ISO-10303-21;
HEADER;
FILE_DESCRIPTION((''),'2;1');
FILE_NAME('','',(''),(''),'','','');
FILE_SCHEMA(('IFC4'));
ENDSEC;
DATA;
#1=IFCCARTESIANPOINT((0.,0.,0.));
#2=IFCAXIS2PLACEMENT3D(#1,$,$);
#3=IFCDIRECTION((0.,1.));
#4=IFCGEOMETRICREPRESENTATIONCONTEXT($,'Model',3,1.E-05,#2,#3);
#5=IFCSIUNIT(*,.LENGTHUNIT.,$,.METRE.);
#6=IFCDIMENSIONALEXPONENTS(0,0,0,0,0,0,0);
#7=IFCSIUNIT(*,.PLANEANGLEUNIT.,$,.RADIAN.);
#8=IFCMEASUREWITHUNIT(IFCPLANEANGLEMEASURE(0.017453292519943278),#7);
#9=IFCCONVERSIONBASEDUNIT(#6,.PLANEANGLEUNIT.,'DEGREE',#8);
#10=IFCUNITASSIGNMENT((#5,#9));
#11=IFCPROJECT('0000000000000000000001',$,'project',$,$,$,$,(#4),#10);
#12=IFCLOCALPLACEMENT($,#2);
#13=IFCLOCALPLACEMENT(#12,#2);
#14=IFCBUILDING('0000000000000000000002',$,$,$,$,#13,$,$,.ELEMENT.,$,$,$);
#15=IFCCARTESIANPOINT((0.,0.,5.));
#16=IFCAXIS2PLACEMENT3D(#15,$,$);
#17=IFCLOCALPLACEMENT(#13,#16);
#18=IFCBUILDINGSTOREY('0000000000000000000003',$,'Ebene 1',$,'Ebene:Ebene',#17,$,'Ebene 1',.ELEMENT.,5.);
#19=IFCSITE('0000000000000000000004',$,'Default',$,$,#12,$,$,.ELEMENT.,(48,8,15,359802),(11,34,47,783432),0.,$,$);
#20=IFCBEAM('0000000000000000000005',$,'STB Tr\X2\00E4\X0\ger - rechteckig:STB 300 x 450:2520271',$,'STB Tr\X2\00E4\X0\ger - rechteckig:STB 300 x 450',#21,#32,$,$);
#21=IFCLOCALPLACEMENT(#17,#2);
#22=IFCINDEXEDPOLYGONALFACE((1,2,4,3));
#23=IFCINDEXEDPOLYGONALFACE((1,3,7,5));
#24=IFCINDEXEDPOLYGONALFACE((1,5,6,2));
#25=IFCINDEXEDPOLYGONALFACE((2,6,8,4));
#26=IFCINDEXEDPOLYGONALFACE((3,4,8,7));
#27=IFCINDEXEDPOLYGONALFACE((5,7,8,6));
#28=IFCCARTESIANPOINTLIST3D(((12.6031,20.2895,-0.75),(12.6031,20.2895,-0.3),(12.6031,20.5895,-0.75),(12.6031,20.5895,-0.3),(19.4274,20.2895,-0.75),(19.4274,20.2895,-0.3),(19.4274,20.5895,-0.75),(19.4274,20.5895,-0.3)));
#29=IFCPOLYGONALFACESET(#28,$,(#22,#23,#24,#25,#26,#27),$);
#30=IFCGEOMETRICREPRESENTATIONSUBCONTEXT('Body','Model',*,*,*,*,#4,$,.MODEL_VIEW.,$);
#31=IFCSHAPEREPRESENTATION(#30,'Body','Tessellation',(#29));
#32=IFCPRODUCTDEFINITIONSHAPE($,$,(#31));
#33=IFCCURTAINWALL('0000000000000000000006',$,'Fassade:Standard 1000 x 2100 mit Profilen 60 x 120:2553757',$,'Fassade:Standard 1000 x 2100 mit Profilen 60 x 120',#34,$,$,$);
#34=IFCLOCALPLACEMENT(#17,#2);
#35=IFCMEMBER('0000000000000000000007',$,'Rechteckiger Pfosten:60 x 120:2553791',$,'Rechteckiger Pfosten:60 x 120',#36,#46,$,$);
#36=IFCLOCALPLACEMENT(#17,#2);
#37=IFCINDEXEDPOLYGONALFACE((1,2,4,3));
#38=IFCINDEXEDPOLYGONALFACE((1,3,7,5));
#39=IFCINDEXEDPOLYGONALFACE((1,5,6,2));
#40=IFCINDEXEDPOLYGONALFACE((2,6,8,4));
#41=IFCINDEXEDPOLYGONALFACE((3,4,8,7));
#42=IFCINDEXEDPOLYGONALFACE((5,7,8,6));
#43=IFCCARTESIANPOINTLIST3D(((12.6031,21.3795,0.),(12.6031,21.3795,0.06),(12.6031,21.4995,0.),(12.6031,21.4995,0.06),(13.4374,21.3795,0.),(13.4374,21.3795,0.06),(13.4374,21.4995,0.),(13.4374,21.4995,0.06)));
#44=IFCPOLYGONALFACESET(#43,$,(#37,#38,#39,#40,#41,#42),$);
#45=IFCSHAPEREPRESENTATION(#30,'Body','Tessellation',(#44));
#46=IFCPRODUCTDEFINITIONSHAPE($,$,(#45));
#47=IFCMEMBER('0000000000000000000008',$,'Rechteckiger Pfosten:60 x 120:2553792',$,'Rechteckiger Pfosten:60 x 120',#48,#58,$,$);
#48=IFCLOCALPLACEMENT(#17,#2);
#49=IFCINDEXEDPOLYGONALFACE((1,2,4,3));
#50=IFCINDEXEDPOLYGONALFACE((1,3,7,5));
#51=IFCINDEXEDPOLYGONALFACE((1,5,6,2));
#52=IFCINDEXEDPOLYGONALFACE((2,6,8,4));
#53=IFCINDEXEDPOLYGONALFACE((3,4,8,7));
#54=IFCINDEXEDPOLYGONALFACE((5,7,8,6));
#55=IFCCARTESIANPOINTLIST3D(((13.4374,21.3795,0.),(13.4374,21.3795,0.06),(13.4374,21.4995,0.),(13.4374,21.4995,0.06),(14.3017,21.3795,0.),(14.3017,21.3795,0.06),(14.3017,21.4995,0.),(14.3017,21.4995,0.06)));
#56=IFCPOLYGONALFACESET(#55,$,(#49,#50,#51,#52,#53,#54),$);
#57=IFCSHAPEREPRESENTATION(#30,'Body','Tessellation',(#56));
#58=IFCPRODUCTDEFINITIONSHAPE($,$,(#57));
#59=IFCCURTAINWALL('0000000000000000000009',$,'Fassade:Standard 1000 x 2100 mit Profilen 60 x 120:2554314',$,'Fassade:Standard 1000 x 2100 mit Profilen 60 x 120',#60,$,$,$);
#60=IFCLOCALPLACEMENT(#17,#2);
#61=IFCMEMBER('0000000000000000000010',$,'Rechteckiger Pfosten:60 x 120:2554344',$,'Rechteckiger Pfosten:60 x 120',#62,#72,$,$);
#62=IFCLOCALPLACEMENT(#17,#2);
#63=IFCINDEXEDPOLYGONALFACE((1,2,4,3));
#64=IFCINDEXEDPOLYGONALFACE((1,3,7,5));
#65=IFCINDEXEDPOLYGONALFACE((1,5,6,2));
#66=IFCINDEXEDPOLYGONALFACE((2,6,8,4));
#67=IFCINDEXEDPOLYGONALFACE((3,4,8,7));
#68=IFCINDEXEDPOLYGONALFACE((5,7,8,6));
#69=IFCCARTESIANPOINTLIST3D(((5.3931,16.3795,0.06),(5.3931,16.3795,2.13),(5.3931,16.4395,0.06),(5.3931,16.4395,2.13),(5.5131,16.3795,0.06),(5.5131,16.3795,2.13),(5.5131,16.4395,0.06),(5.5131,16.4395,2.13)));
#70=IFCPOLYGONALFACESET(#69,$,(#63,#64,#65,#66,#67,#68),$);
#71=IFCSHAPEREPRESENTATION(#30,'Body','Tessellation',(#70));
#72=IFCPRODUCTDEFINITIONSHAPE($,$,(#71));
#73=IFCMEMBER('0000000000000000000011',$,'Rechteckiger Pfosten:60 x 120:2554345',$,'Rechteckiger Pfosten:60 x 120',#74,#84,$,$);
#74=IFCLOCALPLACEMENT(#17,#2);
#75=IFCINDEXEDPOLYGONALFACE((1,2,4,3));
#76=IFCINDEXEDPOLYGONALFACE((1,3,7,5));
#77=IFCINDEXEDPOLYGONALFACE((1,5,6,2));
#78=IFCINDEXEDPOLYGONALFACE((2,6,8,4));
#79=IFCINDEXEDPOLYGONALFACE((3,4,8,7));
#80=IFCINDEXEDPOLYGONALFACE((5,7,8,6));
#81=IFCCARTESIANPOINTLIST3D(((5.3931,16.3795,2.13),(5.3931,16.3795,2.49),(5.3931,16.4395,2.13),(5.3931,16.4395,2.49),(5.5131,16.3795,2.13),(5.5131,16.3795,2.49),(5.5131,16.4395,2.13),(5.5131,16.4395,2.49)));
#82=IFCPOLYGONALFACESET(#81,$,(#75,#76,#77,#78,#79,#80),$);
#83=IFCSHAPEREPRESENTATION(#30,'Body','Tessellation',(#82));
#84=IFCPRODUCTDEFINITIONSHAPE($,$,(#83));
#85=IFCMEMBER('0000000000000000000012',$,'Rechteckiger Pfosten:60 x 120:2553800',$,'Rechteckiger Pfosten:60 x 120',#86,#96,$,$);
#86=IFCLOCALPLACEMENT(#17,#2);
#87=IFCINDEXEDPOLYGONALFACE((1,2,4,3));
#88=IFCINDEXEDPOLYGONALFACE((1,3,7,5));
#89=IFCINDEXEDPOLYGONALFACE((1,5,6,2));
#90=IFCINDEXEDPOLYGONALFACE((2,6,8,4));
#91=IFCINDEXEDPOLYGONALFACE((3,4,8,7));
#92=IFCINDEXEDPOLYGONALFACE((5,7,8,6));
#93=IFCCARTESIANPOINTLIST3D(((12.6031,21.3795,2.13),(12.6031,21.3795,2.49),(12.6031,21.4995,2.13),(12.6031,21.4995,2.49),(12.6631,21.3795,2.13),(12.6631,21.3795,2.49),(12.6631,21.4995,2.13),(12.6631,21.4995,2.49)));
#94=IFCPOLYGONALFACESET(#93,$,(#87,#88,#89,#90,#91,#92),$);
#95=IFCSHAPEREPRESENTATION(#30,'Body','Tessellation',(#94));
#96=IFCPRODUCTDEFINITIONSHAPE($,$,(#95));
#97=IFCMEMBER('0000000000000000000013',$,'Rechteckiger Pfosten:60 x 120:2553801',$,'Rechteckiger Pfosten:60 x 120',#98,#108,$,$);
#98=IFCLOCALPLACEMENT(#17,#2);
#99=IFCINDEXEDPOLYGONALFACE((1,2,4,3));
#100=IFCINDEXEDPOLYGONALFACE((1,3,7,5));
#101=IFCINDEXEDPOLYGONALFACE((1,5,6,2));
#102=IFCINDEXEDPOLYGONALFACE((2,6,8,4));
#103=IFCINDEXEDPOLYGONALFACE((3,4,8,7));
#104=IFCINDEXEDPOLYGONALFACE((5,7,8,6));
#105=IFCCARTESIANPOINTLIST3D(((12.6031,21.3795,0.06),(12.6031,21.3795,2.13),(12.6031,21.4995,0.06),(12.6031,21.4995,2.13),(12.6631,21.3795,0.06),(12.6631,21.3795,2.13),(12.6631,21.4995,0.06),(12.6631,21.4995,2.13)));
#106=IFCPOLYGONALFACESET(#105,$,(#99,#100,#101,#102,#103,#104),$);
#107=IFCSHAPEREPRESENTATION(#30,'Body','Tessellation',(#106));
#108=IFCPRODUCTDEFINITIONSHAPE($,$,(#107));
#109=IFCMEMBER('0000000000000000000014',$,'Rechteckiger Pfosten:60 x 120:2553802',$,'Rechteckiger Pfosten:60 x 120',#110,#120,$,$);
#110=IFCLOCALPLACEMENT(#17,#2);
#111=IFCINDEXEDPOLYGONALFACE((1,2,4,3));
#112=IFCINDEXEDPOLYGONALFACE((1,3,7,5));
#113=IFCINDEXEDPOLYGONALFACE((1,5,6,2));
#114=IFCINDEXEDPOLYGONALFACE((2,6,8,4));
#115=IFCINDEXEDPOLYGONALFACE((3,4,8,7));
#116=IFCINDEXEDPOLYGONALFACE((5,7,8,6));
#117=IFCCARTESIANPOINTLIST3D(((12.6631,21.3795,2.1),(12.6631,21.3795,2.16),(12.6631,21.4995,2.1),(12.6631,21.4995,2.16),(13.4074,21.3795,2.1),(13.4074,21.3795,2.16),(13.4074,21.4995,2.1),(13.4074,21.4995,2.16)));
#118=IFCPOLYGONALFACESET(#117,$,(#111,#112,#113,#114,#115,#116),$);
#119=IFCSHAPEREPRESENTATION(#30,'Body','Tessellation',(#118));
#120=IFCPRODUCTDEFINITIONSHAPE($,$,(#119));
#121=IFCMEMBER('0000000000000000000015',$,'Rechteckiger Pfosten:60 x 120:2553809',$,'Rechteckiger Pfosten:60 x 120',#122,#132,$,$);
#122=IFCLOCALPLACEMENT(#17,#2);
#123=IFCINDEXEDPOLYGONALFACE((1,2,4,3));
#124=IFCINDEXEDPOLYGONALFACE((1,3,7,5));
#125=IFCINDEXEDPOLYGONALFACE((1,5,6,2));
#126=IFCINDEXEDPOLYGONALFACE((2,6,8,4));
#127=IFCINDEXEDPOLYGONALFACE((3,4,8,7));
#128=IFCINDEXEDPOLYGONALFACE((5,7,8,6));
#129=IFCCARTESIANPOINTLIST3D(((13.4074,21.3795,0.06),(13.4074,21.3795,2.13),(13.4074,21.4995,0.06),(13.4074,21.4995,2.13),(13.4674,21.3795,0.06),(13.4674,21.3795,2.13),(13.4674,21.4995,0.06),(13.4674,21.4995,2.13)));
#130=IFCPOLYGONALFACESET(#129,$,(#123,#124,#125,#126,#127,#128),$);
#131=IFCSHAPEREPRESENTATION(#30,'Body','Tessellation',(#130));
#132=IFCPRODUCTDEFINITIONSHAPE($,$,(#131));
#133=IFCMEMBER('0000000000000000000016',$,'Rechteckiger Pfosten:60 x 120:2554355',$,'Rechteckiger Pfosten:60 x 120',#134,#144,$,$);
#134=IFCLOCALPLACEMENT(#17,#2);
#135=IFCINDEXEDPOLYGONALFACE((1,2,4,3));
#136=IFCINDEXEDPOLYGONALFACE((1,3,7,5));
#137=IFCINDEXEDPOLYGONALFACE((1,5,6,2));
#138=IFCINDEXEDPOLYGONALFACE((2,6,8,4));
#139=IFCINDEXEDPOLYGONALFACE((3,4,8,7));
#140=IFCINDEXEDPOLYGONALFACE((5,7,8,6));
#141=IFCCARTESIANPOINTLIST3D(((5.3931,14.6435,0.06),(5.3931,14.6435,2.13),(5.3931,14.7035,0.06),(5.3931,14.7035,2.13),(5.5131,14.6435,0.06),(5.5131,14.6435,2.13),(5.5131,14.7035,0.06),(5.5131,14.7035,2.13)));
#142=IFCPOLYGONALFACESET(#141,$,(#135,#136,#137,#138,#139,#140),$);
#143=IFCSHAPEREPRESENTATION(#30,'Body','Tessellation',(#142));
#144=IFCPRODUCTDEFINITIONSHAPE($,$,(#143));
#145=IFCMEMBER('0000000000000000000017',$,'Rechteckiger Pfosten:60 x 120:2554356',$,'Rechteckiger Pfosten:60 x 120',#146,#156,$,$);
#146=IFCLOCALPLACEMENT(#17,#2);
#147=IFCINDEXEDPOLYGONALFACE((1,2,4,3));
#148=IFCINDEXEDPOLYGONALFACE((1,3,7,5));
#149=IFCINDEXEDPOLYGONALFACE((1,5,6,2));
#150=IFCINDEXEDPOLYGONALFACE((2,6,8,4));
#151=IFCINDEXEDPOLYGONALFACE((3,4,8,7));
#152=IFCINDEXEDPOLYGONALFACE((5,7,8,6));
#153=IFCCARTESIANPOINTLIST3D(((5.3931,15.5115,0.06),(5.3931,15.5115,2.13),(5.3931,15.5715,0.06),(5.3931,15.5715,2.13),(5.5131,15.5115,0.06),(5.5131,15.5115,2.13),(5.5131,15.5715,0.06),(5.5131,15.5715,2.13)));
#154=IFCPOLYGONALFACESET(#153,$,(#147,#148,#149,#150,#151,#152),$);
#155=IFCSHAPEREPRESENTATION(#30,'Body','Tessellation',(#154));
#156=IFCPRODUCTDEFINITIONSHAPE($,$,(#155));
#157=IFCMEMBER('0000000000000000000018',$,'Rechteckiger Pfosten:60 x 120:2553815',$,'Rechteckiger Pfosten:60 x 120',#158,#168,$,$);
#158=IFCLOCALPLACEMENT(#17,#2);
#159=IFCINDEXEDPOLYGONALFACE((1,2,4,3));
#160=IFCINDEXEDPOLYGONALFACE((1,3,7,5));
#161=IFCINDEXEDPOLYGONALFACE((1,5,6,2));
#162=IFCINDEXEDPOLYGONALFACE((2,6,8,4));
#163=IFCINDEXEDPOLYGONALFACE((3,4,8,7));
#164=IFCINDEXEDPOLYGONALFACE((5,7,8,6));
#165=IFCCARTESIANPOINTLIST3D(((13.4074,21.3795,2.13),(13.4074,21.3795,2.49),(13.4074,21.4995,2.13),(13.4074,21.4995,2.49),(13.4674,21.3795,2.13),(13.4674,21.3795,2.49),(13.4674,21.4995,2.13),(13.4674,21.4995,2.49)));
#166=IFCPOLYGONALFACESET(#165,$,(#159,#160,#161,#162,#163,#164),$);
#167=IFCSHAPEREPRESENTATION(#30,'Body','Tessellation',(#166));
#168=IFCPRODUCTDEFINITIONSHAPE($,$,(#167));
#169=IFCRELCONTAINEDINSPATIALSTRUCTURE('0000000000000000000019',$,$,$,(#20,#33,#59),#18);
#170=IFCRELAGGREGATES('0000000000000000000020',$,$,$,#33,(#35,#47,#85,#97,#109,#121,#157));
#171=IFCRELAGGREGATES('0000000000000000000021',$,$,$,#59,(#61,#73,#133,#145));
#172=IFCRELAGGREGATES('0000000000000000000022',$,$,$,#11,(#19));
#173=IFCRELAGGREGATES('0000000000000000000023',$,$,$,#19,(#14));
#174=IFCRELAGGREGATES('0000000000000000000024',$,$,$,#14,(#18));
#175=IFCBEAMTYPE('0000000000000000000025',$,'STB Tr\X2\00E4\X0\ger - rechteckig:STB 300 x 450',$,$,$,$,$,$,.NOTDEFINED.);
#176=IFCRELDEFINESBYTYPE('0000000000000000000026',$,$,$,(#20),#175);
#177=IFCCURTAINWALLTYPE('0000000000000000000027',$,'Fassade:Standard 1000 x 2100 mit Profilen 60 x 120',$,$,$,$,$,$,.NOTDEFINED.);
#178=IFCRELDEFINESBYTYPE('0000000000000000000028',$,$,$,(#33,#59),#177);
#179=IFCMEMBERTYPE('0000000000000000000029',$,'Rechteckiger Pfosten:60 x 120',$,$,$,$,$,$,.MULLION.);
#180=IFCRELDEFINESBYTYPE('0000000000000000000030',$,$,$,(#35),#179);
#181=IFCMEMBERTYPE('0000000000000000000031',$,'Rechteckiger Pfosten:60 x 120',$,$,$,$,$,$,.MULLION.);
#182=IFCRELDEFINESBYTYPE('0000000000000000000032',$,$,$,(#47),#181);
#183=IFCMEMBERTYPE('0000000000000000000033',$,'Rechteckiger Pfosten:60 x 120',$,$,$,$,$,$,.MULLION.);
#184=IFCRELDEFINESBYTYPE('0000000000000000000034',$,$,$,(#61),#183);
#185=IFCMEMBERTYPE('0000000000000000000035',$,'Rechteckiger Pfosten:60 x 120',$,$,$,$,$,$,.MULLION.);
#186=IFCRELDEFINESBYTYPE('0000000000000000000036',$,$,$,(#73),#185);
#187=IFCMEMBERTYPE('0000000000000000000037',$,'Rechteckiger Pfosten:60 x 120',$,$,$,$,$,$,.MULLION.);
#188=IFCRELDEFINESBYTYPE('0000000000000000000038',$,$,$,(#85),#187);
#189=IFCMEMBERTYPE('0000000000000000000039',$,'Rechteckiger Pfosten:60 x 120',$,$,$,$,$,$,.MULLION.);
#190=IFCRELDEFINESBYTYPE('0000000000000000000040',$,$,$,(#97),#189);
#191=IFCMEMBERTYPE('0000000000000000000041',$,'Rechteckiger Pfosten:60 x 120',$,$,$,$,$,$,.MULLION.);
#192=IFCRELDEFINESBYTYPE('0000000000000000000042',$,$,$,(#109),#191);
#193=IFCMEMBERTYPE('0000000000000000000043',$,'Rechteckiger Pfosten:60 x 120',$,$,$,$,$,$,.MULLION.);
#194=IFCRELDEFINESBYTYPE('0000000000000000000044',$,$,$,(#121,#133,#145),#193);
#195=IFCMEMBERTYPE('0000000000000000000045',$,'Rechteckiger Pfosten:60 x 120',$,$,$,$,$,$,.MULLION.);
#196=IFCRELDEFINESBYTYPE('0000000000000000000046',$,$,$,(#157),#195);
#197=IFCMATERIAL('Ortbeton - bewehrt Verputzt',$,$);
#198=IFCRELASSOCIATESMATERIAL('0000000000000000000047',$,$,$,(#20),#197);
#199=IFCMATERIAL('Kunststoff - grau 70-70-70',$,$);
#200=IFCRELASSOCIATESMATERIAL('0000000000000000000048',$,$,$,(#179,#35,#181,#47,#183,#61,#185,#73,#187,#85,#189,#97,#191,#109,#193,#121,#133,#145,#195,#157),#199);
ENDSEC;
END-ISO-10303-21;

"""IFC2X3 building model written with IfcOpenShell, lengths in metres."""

from ifc_helpers import new_model, entity, si_unit, converted_unit, direction, frame, frame_2d, origin, origin_2d_with_axis, place, context, subcontext, project, spatial, rectangle, extrude, source, transform, mapped, material, type_object, type_shapes, element, aggregate, save


model = new_model("IFC2X3")

# Units and contexts
model_context = context("Model", 3, precision=1e-05, world=origin(), true_north=direction((0.0, 1.0)))
body_context = subcontext(model_context, "Body", "Model", "MODEL_VIEW")
ifc_project = project(units=[si_unit("LENGTHUNIT", "METRE"), converted_unit("PLANEANGLEUNIT", "DEGREE", entity("IfcPlaneAngleMeasure", 0.017453292519943278), si_unit("PLANEANGLEUNIT", "RADIAN"), dimensions=[0, 0, 0, 0, 0, 0, 0])], contexts=[model_context])

# Site, building, storey
site_placement = place(None, origin())
site = spatial("IfcSite", under=ifc_project, at=site_placement, Name="Default", CompositionType="ELEMENT", RefLatitude=(48, 8, 15, 359802), RefLongitude=(11, 34, 47, 783432), RefElevation=0.0)
building_placement = place(site_placement, origin())
building = spatial("IfcBuilding", under=site, at=building_placement, CompositionType="ELEMENT")
storey_placement = place(building_placement, frame((0.0, 0.0, 5.0)))
storey = spatial("IfcBuildingStorey", under=building, at=storey_placement, Name="Ebene 1", ObjectType="Ebene:Ebene", LongName="Ebene 1", CompositionType="ELEMENT", Elevation=5.0)

# Beam
ifc_material_1 = material(Name="Ortbeton - bewehrt Verputzt")
beam_type = type_object("IfcBeamType", Name="STB Träger - rechteckig:STB 300 x 450", PredefinedType="NOTDEFINED")
beam_1_placement = place(storey_placement, frame((12.4531, 20.4395, 0.0)))
element("IfcBeam", 1, at=beam_1_placement, inside=storey, type_object=beam_type, material=ifc_material_1, Name="STB Träger - rechteckig:STB 300 x 450:2520271", ObjectType="STB Träger - rechteckig:STB 300 x 450", context=body_context, shape_type="SweptSolid", body=[
    extrude(rectangle(XDim=0.45, YDim=0.3, at=frame_2d((0.0, 0.0), x_axis=(1.0, 0.0))), frame((0.15, 0.0, -0.525), z_axis=(1.0, 0.0, 0.0), x_axis=(0.0, 0.0, -1.0)), (0.0, 0.0, 1.0), 6.8243),
])

# Curtain walls, members
curtain_wall_type = type_object("IfcCurtainWallType", Name="Fassade:Standard 1000 x 2100 mit Profilen 60 x 120", PredefinedType="NOTDEFINED")
curtain_wall_1_placement = place(storey_placement, frame((0.0, 0.0, -5.0)))
curtain_wall_1 = element("IfcCurtainWall", 2, at=curtain_wall_1_placement, inside=storey, type_object=curtain_wall_type, Name="Fassade:Standard 1000 x 2100 mit Profilen 60 x 120:2553757", ObjectType="Fassade:Standard 1000 x 2100 mit Profilen 60 x 120")
ifc_material_2 = material(Name="Kunststoff - grau 70-70-70")
member_type_1 = type_object("IfcMemberType", Name="Rechteckiger Pfosten:60 x 120", PredefinedType="MULLION", material=ifc_material_2)
shared_shape_1 = source(origin(), body_context, "Body", "SweptSolid", [
    extrude(rectangle(XDim=0.06, YDim=0.12, at=origin_2d_with_axis()), frame((-0.03, 0.0, -0.8343), z_axis=(0.0, 0.0, 1.0), x_axis=(-1.0, 0.0, 0.0)), (0.0, 0.0, 1.0), 0.8343),
])
type_shapes(member_type_1, [shared_shape_1])
member_1_placement = place(curtain_wall_1_placement, frame((12.6031, 21.4395, 5.0), z_axis=(-1.0, 0.0, 0.0), x_axis=(0.0, 0.0, -1.0)))
member_1 = element("IfcMember", 3, at=member_1_placement, type_object=member_type_1, material=ifc_material_2, Name="Rechteckiger Pfosten:60 x 120:2553791", ObjectType="Rechteckiger Pfosten:60 x 120", context=body_context, shape_type="MappedRepresentation", body=[
    mapped(shared_shape_1, transform((0.0, 0.0, 0.0), scale=1.0)),
])
member_type_2 = type_object("IfcMemberType", Name="Rechteckiger Pfosten:60 x 120", PredefinedType="MULLION", material=ifc_material_2)
shared_shape_2 = source(origin(), body_context, "Body", "SweptSolid", [
    extrude(rectangle(XDim=0.06, YDim=0.12, at=origin_2d_with_axis()), frame((-0.03, 0.0, -0.8643), z_axis=(0.0, 0.0, 1.0), x_axis=(-1.0, 0.0, 0.0)), (0.0, 0.0, 1.0), 0.8643),
])
type_shapes(member_type_2, [shared_shape_2])
member_2_placement = place(curtain_wall_1_placement, frame((13.4374, 21.4395, 5.0), z_axis=(-1.0, 0.0, 0.0), x_axis=(0.0, 0.0, -1.0)))
member_2 = element("IfcMember", 4, at=member_2_placement, type_object=member_type_2, material=ifc_material_2, Name="Rechteckiger Pfosten:60 x 120:2553792", ObjectType="Rechteckiger Pfosten:60 x 120", context=body_context, shape_type="MappedRepresentation", body=[
    mapped(shared_shape_2, transform((0.0, 0.0, 0.0), scale=1.0)),
])
curtain_wall_2_placement = place(storey_placement, frame((0.0, 0.0, -5.0)))
curtain_wall_2 = element("IfcCurtainWall", 5, at=curtain_wall_2_placement, inside=storey, type_object=curtain_wall_type, Name="Fassade:Standard 1000 x 2100 mit Profilen 60 x 120:2554314", ObjectType="Fassade:Standard 1000 x 2100 mit Profilen 60 x 120")
member_type_3 = type_object("IfcMemberType", Name="Rechteckiger Pfosten:60 x 120", PredefinedType="MULLION", material=ifc_material_2)
shared_shape_3 = source(origin(), body_context, "Body", "SweptSolid", [
    extrude(rectangle(XDim=0.06, YDim=0.12, at=origin_2d_with_axis()), frame((-0.03, 0.0, -2.07), z_axis=(0.0, 0.0, 1.0), x_axis=(-1.0, 0.0, 0.0)), (0.0, 0.0, 1.0), 2.07),
])
type_shapes(member_type_3, [shared_shape_3])
member_3_placement = place(curtain_wall_2_placement, frame((5.4531, 16.4395, 5.06), z_axis=(0.0, 0.0, -1.0), x_axis=(0.0, 1.0, 0.0)))
member_3 = element("IfcMember", 6, at=member_3_placement, type_object=member_type_3, material=ifc_material_2, Name="Rechteckiger Pfosten:60 x 120:2554344", ObjectType="Rechteckiger Pfosten:60 x 120", context=body_context, shape_type="MappedRepresentation", body=[
    mapped(shared_shape_3, transform((0.0, 0.0, 0.0), scale=1.0)),
])
member_type_4 = type_object("IfcMemberType", Name="Rechteckiger Pfosten:60 x 120", PredefinedType="MULLION", material=ifc_material_2)
shared_shape_4 = source(origin(), body_context, "Body", "SweptSolid", [
    extrude(rectangle(XDim=0.06, YDim=0.12, at=origin_2d_with_axis()), frame((-0.03, 0.0, -0.36), z_axis=(0.0, 0.0, 1.0), x_axis=(-1.0, 0.0, 0.0)), (0.0, 0.0, 1.0), 0.36),
])
type_shapes(member_type_4, [shared_shape_4])
member_4_placement = place(curtain_wall_2_placement, frame((5.4531, 16.4395, 7.13), z_axis=(0.0, 0.0, -1.0), x_axis=(0.0, 1.0, 0.0)))
member_4 = element("IfcMember", 7, at=member_4_placement, type_object=member_type_4, material=ifc_material_2, Name="Rechteckiger Pfosten:60 x 120:2554345", ObjectType="Rechteckiger Pfosten:60 x 120", context=body_context, shape_type="MappedRepresentation", body=[
    mapped(shared_shape_4, transform((0.0, 0.0, 0.0), scale=1.0)),
])

# Members
member_type_5 = type_object("IfcMemberType", Name="Rechteckiger Pfosten:60 x 120", PredefinedType="MULLION", material=ifc_material_2)
shared_shape_5 = source(origin(), body_context, "Body", "SweptSolid", [
    extrude(rectangle(XDim=0.06, YDim=0.12, at=origin_2d_with_axis()), frame((-0.03, 0.0, -0.36), z_axis=(0.0, 0.0, 1.0), x_axis=(-1.0, 0.0, 0.0)), (0.0, 0.0, 1.0), 0.36),
])
type_shapes(member_type_5, [shared_shape_5])
member_5_placement = place(curtain_wall_1_placement, frame((12.6031, 21.4395, 7.49), z_axis=(0.0, 0.0, 1.0), x_axis=(-1.0, 0.0, 0.0)))
member_5 = element("IfcMember", 8, at=member_5_placement, type_object=member_type_5, material=ifc_material_2, Name="Rechteckiger Pfosten:60 x 120:2553800", ObjectType="Rechteckiger Pfosten:60 x 120", context=body_context, shape_type="MappedRepresentation", body=[
    mapped(shared_shape_5, transform((0.0, 0.0, 0.0), scale=1.0)),
])
member_type_6 = type_object("IfcMemberType", Name="Rechteckiger Pfosten:60 x 120", PredefinedType="MULLION", material=ifc_material_2)
shared_shape_6 = source(origin(), body_context, "Body", "SweptSolid", [
    extrude(rectangle(XDim=0.06, YDim=0.12, at=origin_2d_with_axis()), frame((-0.03, 0.0, -2.07), z_axis=(0.0, 0.0, 1.0), x_axis=(-1.0, 0.0, 0.0)), (0.0, 0.0, 1.0), 2.07),
])
type_shapes(member_type_6, [shared_shape_6])
member_6_placement = place(curtain_wall_1_placement, frame((12.6031, 21.4395, 7.13), z_axis=(0.0, 0.0, 1.0), x_axis=(-1.0, 0.0, 0.0)))
member_6 = element("IfcMember", 9, at=member_6_placement, type_object=member_type_6, material=ifc_material_2, Name="Rechteckiger Pfosten:60 x 120:2553801", ObjectType="Rechteckiger Pfosten:60 x 120", context=body_context, shape_type="MappedRepresentation", body=[
    mapped(shared_shape_6, transform((0.0, 0.0, 0.0), scale=1.0)),
])
member_type_7 = type_object("IfcMemberType", Name="Rechteckiger Pfosten:60 x 120", PredefinedType="MULLION", material=ifc_material_2)
shared_shape_7 = source(origin(), body_context, "Body", "SweptSolid", [
    extrude(rectangle(XDim=0.06, YDim=0.12, at=frame_2d((0.0, 0.0), x_axis=(1.0, 0.0))), frame((0.0, 0.0, -0.7443), z_axis=(0.0, 0.0, 1.0), x_axis=(-1.0, 0.0, 0.0)), (0.0, 0.0, 1.0), 0.7443),
])
type_shapes(member_type_7, [shared_shape_7])
member_7_placement = place(curtain_wall_1_placement, frame((13.4074, 21.4395, 7.13), z_axis=(1.0, 0.0, 0.0), x_axis=(0.0, 0.0, 1.0)))
member_7 = element("IfcMember", 10, at=member_7_placement, type_object=member_type_7, material=ifc_material_2, Name="Rechteckiger Pfosten:60 x 120:2553802", ObjectType="Rechteckiger Pfosten:60 x 120", context=body_context, shape_type="MappedRepresentation", body=[
    mapped(shared_shape_7, transform((0.0, 0.0, 0.0), scale=1.0)),
])
member_type_8 = type_object("IfcMemberType", Name="Rechteckiger Pfosten:60 x 120", PredefinedType="MULLION", material=ifc_material_2)
shared_shape_8 = source(origin(), body_context, "Body", "SweptSolid", [
    extrude(rectangle(XDim=0.06, YDim=0.12, at=origin_2d_with_axis()), frame((0.0, 0.0, -2.07), z_axis=(0.0, 0.0, 1.0), x_axis=(-1.0, 0.0, 0.0)), (0.0, 0.0, 1.0), 2.07),
])
type_shapes(member_type_8, [shared_shape_8])
member_8_placement = place(curtain_wall_1_placement, frame((13.4374, 21.4395, 5.06), z_axis=(0.0, 0.0, -1.0), x_axis=(1.0, 0.0, 0.0)))
member_8 = element("IfcMember", 11, at=member_8_placement, type_object=member_type_8, material=ifc_material_2, Name="Rechteckiger Pfosten:60 x 120:2553809", ObjectType="Rechteckiger Pfosten:60 x 120", context=body_context, shape_type="MappedRepresentation", body=[
    mapped(shared_shape_8, transform((0.0, 0.0, 0.0), scale=1.0)),
])
member_9_placement = place(curtain_wall_2_placement, frame((5.4531, 14.6735, 5.06), z_axis=(0.0, 0.0, -1.0), x_axis=(0.0, 1.0, 0.0)))
member_9 = element("IfcMember", 12, at=member_9_placement, type_object=member_type_8, material=ifc_material_2, Name="Rechteckiger Pfosten:60 x 120:2554355", ObjectType="Rechteckiger Pfosten:60 x 120", context=body_context, shape_type="MappedRepresentation", body=[
    mapped(shared_shape_8, transform((0.0, 0.0, 0.0), scale=1.0)),
])
member_10_placement = place(curtain_wall_2_placement, frame((5.4531, 15.5415, 5.06), z_axis=(0.0, 0.0, -1.0), x_axis=(0.0, 1.0, 0.0)))
member_10 = element("IfcMember", 13, at=member_10_placement, type_object=member_type_8, material=ifc_material_2, Name="Rechteckiger Pfosten:60 x 120:2554356", ObjectType="Rechteckiger Pfosten:60 x 120", context=body_context, shape_type="MappedRepresentation", body=[
    mapped(shared_shape_8, transform((0.0, 0.0, 0.0), scale=1.0)),
])
member_type_9 = type_object("IfcMemberType", Name="Rechteckiger Pfosten:60 x 120", PredefinedType="MULLION", material=ifc_material_2)
shared_shape_9 = source(origin(), body_context, "Body", "SweptSolid", [
    extrude(rectangle(XDim=0.06, YDim=0.12, at=frame_2d((0.0, 0.0), x_axis=(1.0, 0.0))), frame((0.0, 0.0, -0.36), z_axis=(0.0, 0.0, 1.0), x_axis=(-1.0, 0.0, 0.0)), (0.0, 0.0, 1.0), 0.36),
])
type_shapes(member_type_9, [shared_shape_9])
member_11_placement = place(curtain_wall_1_placement, frame((13.4374, 21.4395, 7.13), z_axis=(0.0, 0.0, -1.0), x_axis=(1.0, 0.0, 0.0)))
member_11 = element("IfcMember", 14, at=member_11_placement, type_object=member_type_9, material=ifc_material_2, Name="Rechteckiger Pfosten:60 x 120:2553815", ObjectType="Rechteckiger Pfosten:60 x 120", context=body_context, shape_type="MappedRepresentation", body=[
    mapped(shared_shape_9, transform((0.0, 0.0, 0.0), scale=1.0)),
])

aggregate(curtain_wall_1, [member_1, member_2, member_5, member_6, member_7, member_8, member_11])
aggregate(curtain_wall_2, [member_3, member_4, member_9, member_10])

save(model, "model.ifc")
